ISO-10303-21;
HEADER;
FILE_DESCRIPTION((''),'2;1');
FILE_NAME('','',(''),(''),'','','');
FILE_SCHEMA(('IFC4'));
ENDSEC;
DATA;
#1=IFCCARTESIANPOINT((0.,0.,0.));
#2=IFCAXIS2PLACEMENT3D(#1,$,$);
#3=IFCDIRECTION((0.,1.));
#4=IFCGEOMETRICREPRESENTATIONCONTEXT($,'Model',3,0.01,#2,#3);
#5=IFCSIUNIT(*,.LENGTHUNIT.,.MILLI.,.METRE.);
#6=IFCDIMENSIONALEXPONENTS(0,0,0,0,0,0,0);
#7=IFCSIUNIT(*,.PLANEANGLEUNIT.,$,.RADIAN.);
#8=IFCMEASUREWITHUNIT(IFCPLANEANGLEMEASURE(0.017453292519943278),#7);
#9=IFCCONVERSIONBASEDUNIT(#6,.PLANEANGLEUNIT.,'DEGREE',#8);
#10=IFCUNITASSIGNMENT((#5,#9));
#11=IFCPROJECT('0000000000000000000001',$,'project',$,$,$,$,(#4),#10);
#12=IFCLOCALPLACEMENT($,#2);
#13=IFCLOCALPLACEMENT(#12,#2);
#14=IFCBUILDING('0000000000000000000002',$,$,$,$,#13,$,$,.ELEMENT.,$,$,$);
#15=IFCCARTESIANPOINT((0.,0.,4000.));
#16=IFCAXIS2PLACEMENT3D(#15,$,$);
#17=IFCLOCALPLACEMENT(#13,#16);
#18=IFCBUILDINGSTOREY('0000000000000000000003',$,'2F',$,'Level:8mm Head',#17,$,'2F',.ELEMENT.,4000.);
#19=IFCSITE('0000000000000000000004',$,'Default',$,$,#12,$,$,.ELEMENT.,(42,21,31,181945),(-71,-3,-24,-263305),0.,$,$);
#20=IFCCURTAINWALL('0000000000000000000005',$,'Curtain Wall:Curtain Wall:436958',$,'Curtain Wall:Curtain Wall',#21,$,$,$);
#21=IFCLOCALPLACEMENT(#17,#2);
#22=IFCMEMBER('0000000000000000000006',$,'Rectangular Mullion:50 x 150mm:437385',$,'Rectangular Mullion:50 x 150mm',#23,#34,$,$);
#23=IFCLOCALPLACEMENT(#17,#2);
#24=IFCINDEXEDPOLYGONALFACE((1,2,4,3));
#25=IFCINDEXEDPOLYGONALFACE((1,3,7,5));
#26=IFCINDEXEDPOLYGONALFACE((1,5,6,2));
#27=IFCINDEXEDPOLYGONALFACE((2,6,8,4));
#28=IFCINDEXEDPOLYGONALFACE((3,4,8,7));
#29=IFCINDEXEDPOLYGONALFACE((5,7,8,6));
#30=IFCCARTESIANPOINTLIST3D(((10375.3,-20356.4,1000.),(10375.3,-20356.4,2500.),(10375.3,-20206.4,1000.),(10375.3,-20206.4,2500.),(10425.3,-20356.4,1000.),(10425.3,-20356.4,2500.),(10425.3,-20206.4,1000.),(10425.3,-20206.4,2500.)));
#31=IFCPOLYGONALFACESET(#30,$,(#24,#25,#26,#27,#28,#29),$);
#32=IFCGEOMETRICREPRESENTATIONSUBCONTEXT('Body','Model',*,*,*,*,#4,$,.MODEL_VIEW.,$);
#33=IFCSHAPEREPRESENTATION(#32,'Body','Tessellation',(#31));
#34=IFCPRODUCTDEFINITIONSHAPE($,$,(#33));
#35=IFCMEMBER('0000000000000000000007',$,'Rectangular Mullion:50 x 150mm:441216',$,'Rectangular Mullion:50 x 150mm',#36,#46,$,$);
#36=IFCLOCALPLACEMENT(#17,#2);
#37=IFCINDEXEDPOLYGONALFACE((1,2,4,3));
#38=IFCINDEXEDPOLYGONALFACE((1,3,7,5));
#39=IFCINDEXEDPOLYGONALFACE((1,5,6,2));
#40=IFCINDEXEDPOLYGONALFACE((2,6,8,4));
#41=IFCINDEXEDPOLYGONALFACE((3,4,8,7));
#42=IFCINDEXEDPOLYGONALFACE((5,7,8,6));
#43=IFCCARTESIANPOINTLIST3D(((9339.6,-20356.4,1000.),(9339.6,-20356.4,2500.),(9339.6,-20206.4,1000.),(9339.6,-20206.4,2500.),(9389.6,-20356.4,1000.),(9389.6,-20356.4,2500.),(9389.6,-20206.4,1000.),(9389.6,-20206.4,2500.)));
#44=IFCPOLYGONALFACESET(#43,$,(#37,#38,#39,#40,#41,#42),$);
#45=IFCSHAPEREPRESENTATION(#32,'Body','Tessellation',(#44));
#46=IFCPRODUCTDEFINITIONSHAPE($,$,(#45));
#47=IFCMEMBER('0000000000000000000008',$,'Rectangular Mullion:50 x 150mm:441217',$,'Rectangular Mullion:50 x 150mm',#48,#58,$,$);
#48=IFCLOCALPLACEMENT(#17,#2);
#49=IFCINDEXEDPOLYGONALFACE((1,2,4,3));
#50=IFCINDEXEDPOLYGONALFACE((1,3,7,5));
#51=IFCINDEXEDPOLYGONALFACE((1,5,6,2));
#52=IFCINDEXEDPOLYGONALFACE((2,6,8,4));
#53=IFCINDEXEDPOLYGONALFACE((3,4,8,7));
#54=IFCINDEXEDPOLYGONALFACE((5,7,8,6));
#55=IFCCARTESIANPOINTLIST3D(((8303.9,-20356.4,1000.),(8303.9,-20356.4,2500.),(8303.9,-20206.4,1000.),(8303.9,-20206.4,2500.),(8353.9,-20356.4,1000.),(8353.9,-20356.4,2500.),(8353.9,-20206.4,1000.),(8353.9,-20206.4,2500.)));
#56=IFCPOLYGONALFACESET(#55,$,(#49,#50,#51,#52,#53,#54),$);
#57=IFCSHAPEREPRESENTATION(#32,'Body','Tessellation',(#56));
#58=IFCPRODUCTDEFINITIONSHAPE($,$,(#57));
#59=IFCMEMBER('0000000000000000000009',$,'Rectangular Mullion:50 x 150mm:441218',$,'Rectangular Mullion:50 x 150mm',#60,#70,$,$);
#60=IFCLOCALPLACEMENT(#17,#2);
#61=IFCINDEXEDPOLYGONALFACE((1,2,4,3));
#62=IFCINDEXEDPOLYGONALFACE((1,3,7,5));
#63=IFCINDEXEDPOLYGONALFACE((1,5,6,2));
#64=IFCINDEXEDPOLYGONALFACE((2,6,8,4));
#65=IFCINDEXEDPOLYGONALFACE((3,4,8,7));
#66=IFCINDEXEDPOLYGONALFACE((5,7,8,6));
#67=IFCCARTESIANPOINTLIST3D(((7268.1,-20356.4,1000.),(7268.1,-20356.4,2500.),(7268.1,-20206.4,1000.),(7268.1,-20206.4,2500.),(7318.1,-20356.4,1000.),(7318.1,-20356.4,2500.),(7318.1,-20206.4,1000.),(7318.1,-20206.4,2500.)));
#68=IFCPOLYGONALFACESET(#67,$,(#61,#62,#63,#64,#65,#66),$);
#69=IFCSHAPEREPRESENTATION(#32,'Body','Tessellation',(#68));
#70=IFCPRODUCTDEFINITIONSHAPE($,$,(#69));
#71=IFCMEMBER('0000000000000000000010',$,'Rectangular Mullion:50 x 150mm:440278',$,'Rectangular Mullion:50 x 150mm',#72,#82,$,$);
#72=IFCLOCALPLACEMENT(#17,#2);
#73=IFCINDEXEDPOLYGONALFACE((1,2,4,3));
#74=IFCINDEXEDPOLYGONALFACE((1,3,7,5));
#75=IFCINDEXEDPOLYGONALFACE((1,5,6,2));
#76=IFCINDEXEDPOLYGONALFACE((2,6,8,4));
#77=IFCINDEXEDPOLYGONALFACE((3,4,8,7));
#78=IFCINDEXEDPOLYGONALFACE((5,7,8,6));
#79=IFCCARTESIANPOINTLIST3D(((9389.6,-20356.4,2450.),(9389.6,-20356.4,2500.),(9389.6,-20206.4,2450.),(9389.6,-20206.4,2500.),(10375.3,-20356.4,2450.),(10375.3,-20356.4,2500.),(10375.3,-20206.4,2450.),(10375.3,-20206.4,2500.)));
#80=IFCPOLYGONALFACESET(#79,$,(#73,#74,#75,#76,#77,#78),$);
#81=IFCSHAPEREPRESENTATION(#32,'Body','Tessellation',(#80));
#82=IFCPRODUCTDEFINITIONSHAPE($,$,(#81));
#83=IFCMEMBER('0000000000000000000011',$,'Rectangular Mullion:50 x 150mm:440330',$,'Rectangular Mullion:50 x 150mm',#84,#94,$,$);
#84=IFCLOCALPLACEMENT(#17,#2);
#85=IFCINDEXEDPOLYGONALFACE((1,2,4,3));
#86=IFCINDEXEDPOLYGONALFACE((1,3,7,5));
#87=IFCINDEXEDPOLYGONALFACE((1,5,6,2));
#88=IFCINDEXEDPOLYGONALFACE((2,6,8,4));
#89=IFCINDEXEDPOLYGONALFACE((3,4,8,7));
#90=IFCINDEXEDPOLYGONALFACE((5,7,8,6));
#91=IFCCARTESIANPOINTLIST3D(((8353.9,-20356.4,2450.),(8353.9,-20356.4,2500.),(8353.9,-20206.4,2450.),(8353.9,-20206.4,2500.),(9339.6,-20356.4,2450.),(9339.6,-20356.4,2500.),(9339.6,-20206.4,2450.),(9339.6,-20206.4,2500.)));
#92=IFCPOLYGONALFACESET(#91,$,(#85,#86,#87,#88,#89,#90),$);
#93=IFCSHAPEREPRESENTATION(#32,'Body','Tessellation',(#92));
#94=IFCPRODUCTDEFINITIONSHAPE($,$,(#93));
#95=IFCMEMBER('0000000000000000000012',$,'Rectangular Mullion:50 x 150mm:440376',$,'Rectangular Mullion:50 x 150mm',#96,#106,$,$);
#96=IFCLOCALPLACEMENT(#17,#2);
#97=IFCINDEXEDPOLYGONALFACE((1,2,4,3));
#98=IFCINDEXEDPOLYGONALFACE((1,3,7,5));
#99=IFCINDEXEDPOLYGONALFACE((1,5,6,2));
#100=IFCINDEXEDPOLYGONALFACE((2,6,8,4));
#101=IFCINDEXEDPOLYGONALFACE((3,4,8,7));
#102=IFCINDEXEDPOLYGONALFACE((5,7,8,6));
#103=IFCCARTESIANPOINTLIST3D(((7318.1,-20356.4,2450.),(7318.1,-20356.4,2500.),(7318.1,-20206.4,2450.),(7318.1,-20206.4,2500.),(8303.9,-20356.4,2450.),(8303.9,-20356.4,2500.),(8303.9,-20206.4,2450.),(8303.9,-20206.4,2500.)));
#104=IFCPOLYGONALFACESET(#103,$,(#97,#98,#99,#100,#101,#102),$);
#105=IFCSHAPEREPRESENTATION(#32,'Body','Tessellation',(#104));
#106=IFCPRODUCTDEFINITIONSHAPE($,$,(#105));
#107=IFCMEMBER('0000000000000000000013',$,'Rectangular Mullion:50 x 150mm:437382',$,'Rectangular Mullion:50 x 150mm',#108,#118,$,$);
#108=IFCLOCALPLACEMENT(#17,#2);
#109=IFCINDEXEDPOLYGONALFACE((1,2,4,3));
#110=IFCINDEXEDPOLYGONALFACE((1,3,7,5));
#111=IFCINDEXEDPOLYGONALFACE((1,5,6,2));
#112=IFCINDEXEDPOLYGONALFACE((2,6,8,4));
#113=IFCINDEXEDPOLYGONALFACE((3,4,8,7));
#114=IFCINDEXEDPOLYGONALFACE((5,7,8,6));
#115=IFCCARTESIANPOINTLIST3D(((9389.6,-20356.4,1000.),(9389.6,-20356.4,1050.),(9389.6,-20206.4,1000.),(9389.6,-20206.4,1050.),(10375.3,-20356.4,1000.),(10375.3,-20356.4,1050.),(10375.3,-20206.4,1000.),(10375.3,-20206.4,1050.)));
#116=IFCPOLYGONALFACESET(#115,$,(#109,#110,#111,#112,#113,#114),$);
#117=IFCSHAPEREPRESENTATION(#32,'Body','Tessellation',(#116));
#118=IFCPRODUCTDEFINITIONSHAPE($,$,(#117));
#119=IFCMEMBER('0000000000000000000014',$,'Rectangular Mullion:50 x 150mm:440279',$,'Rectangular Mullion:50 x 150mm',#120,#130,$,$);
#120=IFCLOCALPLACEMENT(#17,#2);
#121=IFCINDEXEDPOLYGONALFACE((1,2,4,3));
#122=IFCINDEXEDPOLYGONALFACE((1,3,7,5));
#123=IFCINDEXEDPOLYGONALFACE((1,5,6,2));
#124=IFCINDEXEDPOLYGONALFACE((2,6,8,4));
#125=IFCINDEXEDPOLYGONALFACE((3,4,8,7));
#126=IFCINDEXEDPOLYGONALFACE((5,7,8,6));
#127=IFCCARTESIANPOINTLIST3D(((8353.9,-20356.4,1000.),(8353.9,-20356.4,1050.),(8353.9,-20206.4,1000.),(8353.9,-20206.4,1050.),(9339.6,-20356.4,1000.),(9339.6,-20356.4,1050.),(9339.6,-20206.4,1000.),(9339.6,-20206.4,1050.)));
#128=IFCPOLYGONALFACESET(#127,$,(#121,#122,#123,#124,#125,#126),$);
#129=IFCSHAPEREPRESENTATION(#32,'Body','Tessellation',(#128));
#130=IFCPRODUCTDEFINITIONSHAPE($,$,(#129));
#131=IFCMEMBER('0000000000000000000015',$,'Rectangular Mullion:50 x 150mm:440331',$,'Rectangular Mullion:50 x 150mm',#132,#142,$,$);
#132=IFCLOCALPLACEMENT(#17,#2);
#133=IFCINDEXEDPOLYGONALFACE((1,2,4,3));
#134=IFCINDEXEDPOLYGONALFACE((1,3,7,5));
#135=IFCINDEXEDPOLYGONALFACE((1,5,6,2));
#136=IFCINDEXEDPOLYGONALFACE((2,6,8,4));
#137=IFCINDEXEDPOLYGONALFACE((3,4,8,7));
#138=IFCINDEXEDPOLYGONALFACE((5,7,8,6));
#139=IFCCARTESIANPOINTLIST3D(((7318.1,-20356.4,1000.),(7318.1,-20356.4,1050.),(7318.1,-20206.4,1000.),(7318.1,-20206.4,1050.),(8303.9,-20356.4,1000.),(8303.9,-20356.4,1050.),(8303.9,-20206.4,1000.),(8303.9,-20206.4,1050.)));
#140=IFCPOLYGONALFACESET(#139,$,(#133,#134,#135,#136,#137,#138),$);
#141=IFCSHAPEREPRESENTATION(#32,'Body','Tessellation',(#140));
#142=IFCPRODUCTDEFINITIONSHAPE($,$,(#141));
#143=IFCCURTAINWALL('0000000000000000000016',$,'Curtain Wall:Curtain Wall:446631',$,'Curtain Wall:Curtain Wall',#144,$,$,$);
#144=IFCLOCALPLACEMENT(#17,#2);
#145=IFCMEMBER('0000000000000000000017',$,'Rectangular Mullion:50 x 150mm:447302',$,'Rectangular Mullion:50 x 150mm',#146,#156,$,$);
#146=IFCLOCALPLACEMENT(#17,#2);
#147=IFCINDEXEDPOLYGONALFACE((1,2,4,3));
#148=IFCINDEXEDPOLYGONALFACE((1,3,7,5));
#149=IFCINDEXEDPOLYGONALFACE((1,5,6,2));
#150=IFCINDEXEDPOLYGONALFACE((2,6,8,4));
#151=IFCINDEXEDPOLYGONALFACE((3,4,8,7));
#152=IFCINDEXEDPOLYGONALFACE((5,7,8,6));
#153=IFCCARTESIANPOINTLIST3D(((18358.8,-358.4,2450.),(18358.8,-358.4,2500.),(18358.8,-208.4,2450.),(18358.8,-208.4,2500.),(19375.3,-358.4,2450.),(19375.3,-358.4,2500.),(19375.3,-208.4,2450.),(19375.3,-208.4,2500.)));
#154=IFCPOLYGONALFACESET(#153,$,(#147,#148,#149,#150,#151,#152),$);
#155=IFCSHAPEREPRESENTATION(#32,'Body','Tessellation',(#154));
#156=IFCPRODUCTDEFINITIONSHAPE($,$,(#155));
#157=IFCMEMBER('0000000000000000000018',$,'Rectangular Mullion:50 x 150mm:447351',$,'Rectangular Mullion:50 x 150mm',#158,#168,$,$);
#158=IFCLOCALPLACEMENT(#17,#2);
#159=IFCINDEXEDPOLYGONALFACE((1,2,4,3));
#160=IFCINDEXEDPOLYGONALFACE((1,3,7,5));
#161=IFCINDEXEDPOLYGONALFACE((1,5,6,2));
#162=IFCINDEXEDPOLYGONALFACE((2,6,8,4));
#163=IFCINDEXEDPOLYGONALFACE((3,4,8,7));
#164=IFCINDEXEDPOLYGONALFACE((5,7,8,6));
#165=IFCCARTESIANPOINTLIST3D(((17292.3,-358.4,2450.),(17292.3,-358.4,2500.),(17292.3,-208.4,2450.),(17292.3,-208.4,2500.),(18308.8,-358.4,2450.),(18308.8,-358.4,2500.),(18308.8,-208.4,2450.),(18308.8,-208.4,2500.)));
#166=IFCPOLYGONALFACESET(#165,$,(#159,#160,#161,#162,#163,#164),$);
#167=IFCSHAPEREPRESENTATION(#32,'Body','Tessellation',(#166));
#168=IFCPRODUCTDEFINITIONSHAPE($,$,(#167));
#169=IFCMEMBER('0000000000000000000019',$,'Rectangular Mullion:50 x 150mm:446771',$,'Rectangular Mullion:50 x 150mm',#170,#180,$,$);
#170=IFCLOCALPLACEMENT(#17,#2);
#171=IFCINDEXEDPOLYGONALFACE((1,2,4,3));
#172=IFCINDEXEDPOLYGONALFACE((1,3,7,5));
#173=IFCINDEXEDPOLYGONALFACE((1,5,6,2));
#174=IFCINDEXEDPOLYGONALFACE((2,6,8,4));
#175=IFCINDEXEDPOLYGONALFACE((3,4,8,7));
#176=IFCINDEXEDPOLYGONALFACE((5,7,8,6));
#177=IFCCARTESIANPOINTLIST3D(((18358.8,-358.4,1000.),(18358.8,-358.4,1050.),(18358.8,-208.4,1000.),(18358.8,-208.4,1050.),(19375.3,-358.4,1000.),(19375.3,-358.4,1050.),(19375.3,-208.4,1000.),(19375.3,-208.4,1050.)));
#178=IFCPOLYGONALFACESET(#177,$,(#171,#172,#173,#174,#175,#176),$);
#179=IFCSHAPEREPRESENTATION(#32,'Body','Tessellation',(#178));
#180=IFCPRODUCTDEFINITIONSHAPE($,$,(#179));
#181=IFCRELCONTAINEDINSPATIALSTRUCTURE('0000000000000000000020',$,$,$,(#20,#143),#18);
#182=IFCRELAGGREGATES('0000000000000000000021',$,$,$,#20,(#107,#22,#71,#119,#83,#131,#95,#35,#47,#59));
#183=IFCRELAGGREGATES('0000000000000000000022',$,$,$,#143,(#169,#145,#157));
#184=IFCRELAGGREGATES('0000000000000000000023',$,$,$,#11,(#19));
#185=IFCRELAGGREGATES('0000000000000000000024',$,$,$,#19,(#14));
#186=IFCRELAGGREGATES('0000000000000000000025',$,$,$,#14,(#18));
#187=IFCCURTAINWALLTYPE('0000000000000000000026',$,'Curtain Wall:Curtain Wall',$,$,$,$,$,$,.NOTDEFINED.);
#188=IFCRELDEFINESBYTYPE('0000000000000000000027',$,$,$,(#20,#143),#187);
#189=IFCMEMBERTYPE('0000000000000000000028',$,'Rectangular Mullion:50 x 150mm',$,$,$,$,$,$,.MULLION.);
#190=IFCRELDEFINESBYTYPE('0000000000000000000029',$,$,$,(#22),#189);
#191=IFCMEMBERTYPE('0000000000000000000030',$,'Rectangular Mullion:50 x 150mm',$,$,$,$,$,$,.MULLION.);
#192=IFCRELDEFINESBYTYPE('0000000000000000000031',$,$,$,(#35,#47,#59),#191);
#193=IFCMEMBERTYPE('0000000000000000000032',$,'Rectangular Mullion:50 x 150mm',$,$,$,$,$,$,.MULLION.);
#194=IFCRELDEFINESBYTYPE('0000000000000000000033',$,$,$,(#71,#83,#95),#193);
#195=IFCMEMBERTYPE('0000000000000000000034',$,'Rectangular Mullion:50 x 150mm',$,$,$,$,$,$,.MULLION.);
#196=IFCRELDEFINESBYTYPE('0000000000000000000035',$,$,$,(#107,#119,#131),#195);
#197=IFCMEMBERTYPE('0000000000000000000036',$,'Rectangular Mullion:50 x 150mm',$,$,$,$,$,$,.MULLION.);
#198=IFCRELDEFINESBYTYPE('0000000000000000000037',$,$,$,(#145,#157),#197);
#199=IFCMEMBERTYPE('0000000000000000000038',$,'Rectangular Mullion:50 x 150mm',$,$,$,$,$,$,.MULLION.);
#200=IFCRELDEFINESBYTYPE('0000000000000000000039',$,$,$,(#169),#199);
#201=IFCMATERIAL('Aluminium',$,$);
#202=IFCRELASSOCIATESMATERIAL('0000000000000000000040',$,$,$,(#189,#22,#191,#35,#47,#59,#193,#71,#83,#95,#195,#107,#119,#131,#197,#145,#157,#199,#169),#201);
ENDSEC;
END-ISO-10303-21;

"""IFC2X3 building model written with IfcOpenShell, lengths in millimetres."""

from ifc_helpers import new_model, entity, si_unit, converted_unit, direction, frame, origin, origin_2d_with_axis, place, context, subcontext, project, spatial, rectangle, extrude, source, transform, mapped, material, type_object, type_shapes, element, aggregate, save


model = new_model("IFC2X3")

# Units and contexts
model_context = context("Model", 3, precision=0.01, world=origin(), true_north=direction((0.0, 1.0)))
body_context = subcontext(model_context, "Body", "Model", "MODEL_VIEW")
ifc_project = project(units=[si_unit("LENGTHUNIT", "METRE", prefix="MILLI"), converted_unit("PLANEANGLEUNIT", "DEGREE", entity("IfcPlaneAngleMeasure", 0.017453292519943278), si_unit("PLANEANGLEUNIT", "RADIAN"), dimensions=[0, 0, 0, 0, 0, 0, 0])], contexts=[model_context])

# Site, building, storey
site_placement = place(None, origin())
site = spatial("IfcSite", under=ifc_project, at=site_placement, Name="Default", CompositionType="ELEMENT", RefLatitude=(42, 21, 31, 181945), RefLongitude=(-71, -3, -24, -263305), RefElevation=0.0)
building_placement = place(site_placement, origin())
building = spatial("IfcBuilding", under=site, at=building_placement, CompositionType="ELEMENT")
storey_placement = place(building_placement, frame((0.0, 0.0, 4000.0)))
storey = spatial("IfcBuildingStorey", under=building, at=storey_placement, Name="2F", ObjectType="Level:8mm Head", LongName="2F", CompositionType="ELEMENT", Elevation=4000.0)

# Curtain walls, members
curtain_wall_type = type_object("IfcCurtainWallType", Name="Curtain Wall:Curtain Wall", PredefinedType="NOTDEFINED")
curtain_wall_1_placement = place(storey_placement, frame((0.0, 0.0, -4000.0)))
curtain_wall_1 = element("IfcCurtainWall", 1, at=curtain_wall_1_placement, inside=storey, type_object=curtain_wall_type, Name="Curtain Wall:Curtain Wall:436958", ObjectType="Curtain Wall:Curtain Wall")
ifc_material_1 = material(Name="Aluminium")
member_type_1 = type_object("IfcMemberType", Name="Rectangular Mullion:50 x 150mm", PredefinedType="MULLION", material=ifc_material_1)
shared_shape_1 = source(origin(), body_context, "Body", "SweptSolid", [
    extrude(rectangle(XDim=50.0, YDim=150.0, at=origin_2d_with_axis()), frame((-25.0, 0.0, -1500.0), z_axis=(0.0, 0.0, 1.0), x_axis=(-1.0, 0.0, 0.0)), (0.0, 0.0, 1.0), 1500.0),
])
type_shapes(member_type_1, [shared_shape_1])
member_1_placement = place(curtain_wall_1_placement, frame((10425.3, -20281.4, 6500.0)))
member_1 = element("IfcMember", 2, at=member_1_placement, type_object=member_type_1, material=ifc_material_1, Name="Rectangular Mullion:50 x 150mm:437385", ObjectType="Rectangular Mullion:50 x 150mm", context=body_context, shape_type="MappedRepresentation", body=[
    mapped(shared_shape_1, transform((0.0, 0.0, 0.0), scale=1.0)),
])
member_type_2 = type_object("IfcMemberType", Name="Rectangular Mullion:50 x 150mm", PredefinedType="MULLION", material=ifc_material_1)
shared_shape_2 = source(origin(), body_context, "Body", "SweptSolid", [
    extrude(rectangle(XDim=50.0, YDim=150.0, at=origin_2d_with_axis()), frame((0.0, 0.0, -1500.0), z_axis=(0.0, 0.0, 1.0), x_axis=(-1.0, 0.0, 0.0)), (0.0, 0.0, 1.0), 1500.0),
])
type_shapes(member_type_2, [shared_shape_2])
member_2_placement = place(curtain_wall_1_placement, frame((9364.6, -20281.4, 5000.0), z_axis=(0.0, 0.0, -1.0), x_axis=(-1.0, 0.0, 0.0)))
member_2 = element("IfcMember", 3, at=member_2_placement, type_object=member_type_2, material=ifc_material_1, Name="Rectangular Mullion:50 x 150mm:441216", ObjectType="Rectangular Mullion:50 x 150mm", context=body_context, shape_type="MappedRepresentation", body=[
    mapped(shared_shape_2, transform((0.0, 0.0, 0.0), scale=1.0)),
])
member_3_placement = place(curtain_wall_1_placement, frame((8328.9, -20281.4, 5000.0), z_axis=(0.0, 0.0, -1.0), x_axis=(-1.0, 0.0, 0.0)))
member_3 = element("IfcMember", 4, at=member_3_placement, type_object=member_type_2, material=ifc_material_1, Name="Rectangular Mullion:50 x 150mm:441217", ObjectType="Rectangular Mullion:50 x 150mm", context=body_context, shape_type="MappedRepresentation", body=[
    mapped(shared_shape_2, transform((0.0, 0.0, 0.0), scale=1.0)),
])
member_4_placement = place(curtain_wall_1_placement, frame((7293.1, -20281.4, 5000.0), z_axis=(0.0, 0.0, -1.0), x_axis=(-1.0, 0.0, 0.0)))
member_4 = element("IfcMember", 5, at=member_4_placement, type_object=member_type_2, material=ifc_material_1, Name="Rectangular Mullion:50 x 150mm:441218", ObjectType="Rectangular Mullion:50 x 150mm", context=body_context, shape_type="MappedRepresentation", body=[
    mapped(shared_shape_2, transform((0.0, 0.0, 0.0), scale=1.0)),
])
member_type_3 = type_object("IfcMemberType", Name="Rectangular Mullion:50 x 150mm", PredefinedType="MULLION", material=ifc_material_1)
shared_shape_3 = source(origin(), body_context, "Body", "SweptSolid", [
    extrude(rectangle(XDim=50.0, YDim=150.0, at=origin_2d_with_axis()), frame((-25.0, 0.0, -985.7), z_axis=(0.0, 0.0, 1.0), x_axis=(-1.0, 0.0, 0.0)), (0.0, 0.0, 1.0), 985.7),
])
type_shapes(member_type_3, [shared_shape_3])
member_5_placement = place(curtain_wall_1_placement, frame((9389.6, -20281.4, 6500.0), z_axis=(-1.0, 0.0, 0.0), x_axis=(0.0, 0.0, 1.0)))
member_5 = element("IfcMember", 6, at=member_5_placement, type_object=member_type_3, material=ifc_material_1, Name="Rectangular Mullion:50 x 150mm:440278", ObjectType="Rectangular Mullion:50 x 150mm", context=body_context, shape_type="MappedRepresentation", body=[
    mapped(shared_shape_3, transform((0.0, 0.0, 0.0), scale=1.0)),
])
member_6_placement = place(curtain_wall_1_placement, frame((8353.9, -20281.4, 6500.0), z_axis=(-1.0, 0.0, 0.0), x_axis=(0.0, 0.0, 1.0)))
member_6 = element("IfcMember", 7, at=member_6_placement, type_object=member_type_3, material=ifc_material_1, Name="Rectangular Mullion:50 x 150mm:440330", ObjectType="Rectangular Mullion:50 x 150mm", context=body_context, shape_type="MappedRepresentation", body=[
    mapped(shared_shape_3, transform((0.0, 0.0, 0.0), scale=1.0)),
])
member_7_placement = place(curtain_wall_1_placement, frame((7318.1, -20281.4, 6500.0), z_axis=(-1.0, 0.0, 0.0), x_axis=(0.0, 0.0, 1.0)))
member_7 = element("IfcMember", 8, at=member_7_placement, type_object=member_type_3, material=ifc_material_1, Name="Rectangular Mullion:50 x 150mm:440376", ObjectType="Rectangular Mullion:50 x 150mm", context=body_context, shape_type="MappedRepresentation", body=[
    mapped(shared_shape_3, transform((0.0, 0.0, 0.0), scale=1.0)),
])
member_type_4 = type_object("IfcMemberType", Name="Rectangular Mullion:50 x 150mm", PredefinedType="MULLION", material=ifc_material_1)
shared_shape_4 = source(origin(), body_context, "Body", "SweptSolid", [
    extrude(rectangle(XDim=50.0, YDim=150.0, at=origin_2d_with_axis()), frame((-25.0, 0.0, -985.7), z_axis=(0.0, 0.0, 1.0), x_axis=(-1.0, 0.0, 0.0)), (0.0, 0.0, 1.0), 985.7),
])
type_shapes(member_type_4, [shared_shape_4])
member_8_placement = place(curtain_wall_1_placement, frame((10375.3, -20281.4, 5000.0), z_axis=(1.0, 0.0, 0.0), x_axis=(0.0, 0.0, -1.0)))
member_8 = element("IfcMember", 9, at=member_8_placement, type_object=member_type_4, material=ifc_material_1, Name="Rectangular Mullion:50 x 150mm:437382", ObjectType="Rectangular Mullion:50 x 150mm", context=body_context, shape_type="MappedRepresentation", body=[
    mapped(shared_shape_4, transform((0.0, 0.0, 0.0), scale=1.0)),
])
member_9_placement = place(curtain_wall_1_placement, frame((9339.6, -20281.4, 5000.0), z_axis=(1.0, 0.0, 0.0), x_axis=(0.0, 0.0, -1.0)))
member_9 = element("IfcMember", 10, at=member_9_placement, type_object=member_type_4, material=ifc_material_1, Name="Rectangular Mullion:50 x 150mm:440279", ObjectType="Rectangular Mullion:50 x 150mm", context=body_context, shape_type="MappedRepresentation", body=[
    mapped(shared_shape_4, transform((0.0, 0.0, 0.0), scale=1.0)),
])
member_10_placement = place(curtain_wall_1_placement, frame((8303.9, -20281.4, 5000.0), z_axis=(1.0, 0.0, 0.0), x_axis=(0.0, 0.0, -1.0)))
member_10 = element("IfcMember", 11, at=member_10_placement, type_object=member_type_4, material=ifc_material_1, Name="Rectangular Mullion:50 x 150mm:440331", ObjectType="Rectangular Mullion:50 x 150mm", context=body_context, shape_type="MappedRepresentation", body=[
    mapped(shared_shape_4, transform((0.0, 0.0, 0.0), scale=1.0)),
])
curtain_wall_2_placement = place(storey_placement, frame((0.0, 0.0, -4000.0)))
curtain_wall_2 = element("IfcCurtainWall", 12, at=curtain_wall_2_placement, inside=storey, type_object=curtain_wall_type, Name="Curtain Wall:Curtain Wall:446631", ObjectType="Curtain Wall:Curtain Wall")
member_type_5 = type_object("IfcMemberType", Name="Rectangular Mullion:50 x 150mm", PredefinedType="MULLION", material=ifc_material_1)
shared_shape_5 = source(origin(), body_context, "Body", "SweptSolid", [
    extrude(rectangle(XDim=50.0, YDim=150.0, at=origin_2d_with_axis()), frame((-25.0, 0.0, -1016.5), z_axis=(0.0, 0.0, 1.0), x_axis=(-1.0, 0.0, 0.0)), (0.0, 0.0, 1.0), 1016.5),
])
type_shapes(member_type_5, [shared_shape_5])
member_11_placement = place(curtain_wall_2_placement, frame((18358.8, -283.4, 6500.0), z_axis=(-1.0, 0.0, 0.0), x_axis=(0.0, 0.0, 1.0)))
member_11 = element("IfcMember", 13, at=member_11_placement, type_object=member_type_5, material=ifc_material_1, Name="Rectangular Mullion:50 x 150mm:447302", ObjectType="Rectangular Mullion:50 x 150mm", context=body_context, shape_type="MappedRepresentation", body=[
    mapped(shared_shape_5, transform((0.0, 0.0, 0.0), scale=1.0)),
])
member_12_placement = place(curtain_wall_2_placement, frame((17292.3, -283.4, 6500.0), z_axis=(-1.0, 0.0, 0.0), x_axis=(0.0, 0.0, 1.0)))
member_12 = element("IfcMember", 14, at=member_12_placement, type_object=member_type_5, material=ifc_material_1, Name="Rectangular Mullion:50 x 150mm:447351", ObjectType="Rectangular Mullion:50 x 150mm", context=body_context, shape_type="MappedRepresentation", body=[
    mapped(shared_shape_5, transform((0.0, 0.0, 0.0), scale=1.0)),
])
member_type_6 = type_object("IfcMemberType", Name="Rectangular Mullion:50 x 150mm", PredefinedType="MULLION", material=ifc_material_1)
shared_shape_6 = source(origin(), body_context, "Body", "SweptSolid", [
    extrude(rectangle(XDim=50.0, YDim=150.0, at=origin_2d_with_axis()), frame((-25.0, 0.0, -1016.5), z_axis=(0.0, 0.0, 1.0), x_axis=(-1.0, 0.0, 0.0)), (0.0, 0.0, 1.0), 1016.5),
])
type_shapes(member_type_6, [shared_shape_6])
member_13_placement = place(curtain_wall_2_placement, frame((19375.3, -283.4, 5000.0), z_axis=(1.0, 0.0, 0.0), x_axis=(0.0, 0.0, -1.0)))
member_13 = element("IfcMember", 15, at=member_13_placement, type_object=member_type_6, material=ifc_material_1, Name="Rectangular Mullion:50 x 150mm:446771", ObjectType="Rectangular Mullion:50 x 150mm", context=body_context, shape_type="MappedRepresentation", body=[
    mapped(shared_shape_6, transform((0.0, 0.0, 0.0), scale=1.0)),
])

aggregate(curtain_wall_1, [member_8, member_1, member_5, member_9, member_6, member_10, member_7, member_2, member_3, member_4])
aggregate(curtain_wall_2, [member_13, member_11, member_12])

save(model, "model.ifc")
